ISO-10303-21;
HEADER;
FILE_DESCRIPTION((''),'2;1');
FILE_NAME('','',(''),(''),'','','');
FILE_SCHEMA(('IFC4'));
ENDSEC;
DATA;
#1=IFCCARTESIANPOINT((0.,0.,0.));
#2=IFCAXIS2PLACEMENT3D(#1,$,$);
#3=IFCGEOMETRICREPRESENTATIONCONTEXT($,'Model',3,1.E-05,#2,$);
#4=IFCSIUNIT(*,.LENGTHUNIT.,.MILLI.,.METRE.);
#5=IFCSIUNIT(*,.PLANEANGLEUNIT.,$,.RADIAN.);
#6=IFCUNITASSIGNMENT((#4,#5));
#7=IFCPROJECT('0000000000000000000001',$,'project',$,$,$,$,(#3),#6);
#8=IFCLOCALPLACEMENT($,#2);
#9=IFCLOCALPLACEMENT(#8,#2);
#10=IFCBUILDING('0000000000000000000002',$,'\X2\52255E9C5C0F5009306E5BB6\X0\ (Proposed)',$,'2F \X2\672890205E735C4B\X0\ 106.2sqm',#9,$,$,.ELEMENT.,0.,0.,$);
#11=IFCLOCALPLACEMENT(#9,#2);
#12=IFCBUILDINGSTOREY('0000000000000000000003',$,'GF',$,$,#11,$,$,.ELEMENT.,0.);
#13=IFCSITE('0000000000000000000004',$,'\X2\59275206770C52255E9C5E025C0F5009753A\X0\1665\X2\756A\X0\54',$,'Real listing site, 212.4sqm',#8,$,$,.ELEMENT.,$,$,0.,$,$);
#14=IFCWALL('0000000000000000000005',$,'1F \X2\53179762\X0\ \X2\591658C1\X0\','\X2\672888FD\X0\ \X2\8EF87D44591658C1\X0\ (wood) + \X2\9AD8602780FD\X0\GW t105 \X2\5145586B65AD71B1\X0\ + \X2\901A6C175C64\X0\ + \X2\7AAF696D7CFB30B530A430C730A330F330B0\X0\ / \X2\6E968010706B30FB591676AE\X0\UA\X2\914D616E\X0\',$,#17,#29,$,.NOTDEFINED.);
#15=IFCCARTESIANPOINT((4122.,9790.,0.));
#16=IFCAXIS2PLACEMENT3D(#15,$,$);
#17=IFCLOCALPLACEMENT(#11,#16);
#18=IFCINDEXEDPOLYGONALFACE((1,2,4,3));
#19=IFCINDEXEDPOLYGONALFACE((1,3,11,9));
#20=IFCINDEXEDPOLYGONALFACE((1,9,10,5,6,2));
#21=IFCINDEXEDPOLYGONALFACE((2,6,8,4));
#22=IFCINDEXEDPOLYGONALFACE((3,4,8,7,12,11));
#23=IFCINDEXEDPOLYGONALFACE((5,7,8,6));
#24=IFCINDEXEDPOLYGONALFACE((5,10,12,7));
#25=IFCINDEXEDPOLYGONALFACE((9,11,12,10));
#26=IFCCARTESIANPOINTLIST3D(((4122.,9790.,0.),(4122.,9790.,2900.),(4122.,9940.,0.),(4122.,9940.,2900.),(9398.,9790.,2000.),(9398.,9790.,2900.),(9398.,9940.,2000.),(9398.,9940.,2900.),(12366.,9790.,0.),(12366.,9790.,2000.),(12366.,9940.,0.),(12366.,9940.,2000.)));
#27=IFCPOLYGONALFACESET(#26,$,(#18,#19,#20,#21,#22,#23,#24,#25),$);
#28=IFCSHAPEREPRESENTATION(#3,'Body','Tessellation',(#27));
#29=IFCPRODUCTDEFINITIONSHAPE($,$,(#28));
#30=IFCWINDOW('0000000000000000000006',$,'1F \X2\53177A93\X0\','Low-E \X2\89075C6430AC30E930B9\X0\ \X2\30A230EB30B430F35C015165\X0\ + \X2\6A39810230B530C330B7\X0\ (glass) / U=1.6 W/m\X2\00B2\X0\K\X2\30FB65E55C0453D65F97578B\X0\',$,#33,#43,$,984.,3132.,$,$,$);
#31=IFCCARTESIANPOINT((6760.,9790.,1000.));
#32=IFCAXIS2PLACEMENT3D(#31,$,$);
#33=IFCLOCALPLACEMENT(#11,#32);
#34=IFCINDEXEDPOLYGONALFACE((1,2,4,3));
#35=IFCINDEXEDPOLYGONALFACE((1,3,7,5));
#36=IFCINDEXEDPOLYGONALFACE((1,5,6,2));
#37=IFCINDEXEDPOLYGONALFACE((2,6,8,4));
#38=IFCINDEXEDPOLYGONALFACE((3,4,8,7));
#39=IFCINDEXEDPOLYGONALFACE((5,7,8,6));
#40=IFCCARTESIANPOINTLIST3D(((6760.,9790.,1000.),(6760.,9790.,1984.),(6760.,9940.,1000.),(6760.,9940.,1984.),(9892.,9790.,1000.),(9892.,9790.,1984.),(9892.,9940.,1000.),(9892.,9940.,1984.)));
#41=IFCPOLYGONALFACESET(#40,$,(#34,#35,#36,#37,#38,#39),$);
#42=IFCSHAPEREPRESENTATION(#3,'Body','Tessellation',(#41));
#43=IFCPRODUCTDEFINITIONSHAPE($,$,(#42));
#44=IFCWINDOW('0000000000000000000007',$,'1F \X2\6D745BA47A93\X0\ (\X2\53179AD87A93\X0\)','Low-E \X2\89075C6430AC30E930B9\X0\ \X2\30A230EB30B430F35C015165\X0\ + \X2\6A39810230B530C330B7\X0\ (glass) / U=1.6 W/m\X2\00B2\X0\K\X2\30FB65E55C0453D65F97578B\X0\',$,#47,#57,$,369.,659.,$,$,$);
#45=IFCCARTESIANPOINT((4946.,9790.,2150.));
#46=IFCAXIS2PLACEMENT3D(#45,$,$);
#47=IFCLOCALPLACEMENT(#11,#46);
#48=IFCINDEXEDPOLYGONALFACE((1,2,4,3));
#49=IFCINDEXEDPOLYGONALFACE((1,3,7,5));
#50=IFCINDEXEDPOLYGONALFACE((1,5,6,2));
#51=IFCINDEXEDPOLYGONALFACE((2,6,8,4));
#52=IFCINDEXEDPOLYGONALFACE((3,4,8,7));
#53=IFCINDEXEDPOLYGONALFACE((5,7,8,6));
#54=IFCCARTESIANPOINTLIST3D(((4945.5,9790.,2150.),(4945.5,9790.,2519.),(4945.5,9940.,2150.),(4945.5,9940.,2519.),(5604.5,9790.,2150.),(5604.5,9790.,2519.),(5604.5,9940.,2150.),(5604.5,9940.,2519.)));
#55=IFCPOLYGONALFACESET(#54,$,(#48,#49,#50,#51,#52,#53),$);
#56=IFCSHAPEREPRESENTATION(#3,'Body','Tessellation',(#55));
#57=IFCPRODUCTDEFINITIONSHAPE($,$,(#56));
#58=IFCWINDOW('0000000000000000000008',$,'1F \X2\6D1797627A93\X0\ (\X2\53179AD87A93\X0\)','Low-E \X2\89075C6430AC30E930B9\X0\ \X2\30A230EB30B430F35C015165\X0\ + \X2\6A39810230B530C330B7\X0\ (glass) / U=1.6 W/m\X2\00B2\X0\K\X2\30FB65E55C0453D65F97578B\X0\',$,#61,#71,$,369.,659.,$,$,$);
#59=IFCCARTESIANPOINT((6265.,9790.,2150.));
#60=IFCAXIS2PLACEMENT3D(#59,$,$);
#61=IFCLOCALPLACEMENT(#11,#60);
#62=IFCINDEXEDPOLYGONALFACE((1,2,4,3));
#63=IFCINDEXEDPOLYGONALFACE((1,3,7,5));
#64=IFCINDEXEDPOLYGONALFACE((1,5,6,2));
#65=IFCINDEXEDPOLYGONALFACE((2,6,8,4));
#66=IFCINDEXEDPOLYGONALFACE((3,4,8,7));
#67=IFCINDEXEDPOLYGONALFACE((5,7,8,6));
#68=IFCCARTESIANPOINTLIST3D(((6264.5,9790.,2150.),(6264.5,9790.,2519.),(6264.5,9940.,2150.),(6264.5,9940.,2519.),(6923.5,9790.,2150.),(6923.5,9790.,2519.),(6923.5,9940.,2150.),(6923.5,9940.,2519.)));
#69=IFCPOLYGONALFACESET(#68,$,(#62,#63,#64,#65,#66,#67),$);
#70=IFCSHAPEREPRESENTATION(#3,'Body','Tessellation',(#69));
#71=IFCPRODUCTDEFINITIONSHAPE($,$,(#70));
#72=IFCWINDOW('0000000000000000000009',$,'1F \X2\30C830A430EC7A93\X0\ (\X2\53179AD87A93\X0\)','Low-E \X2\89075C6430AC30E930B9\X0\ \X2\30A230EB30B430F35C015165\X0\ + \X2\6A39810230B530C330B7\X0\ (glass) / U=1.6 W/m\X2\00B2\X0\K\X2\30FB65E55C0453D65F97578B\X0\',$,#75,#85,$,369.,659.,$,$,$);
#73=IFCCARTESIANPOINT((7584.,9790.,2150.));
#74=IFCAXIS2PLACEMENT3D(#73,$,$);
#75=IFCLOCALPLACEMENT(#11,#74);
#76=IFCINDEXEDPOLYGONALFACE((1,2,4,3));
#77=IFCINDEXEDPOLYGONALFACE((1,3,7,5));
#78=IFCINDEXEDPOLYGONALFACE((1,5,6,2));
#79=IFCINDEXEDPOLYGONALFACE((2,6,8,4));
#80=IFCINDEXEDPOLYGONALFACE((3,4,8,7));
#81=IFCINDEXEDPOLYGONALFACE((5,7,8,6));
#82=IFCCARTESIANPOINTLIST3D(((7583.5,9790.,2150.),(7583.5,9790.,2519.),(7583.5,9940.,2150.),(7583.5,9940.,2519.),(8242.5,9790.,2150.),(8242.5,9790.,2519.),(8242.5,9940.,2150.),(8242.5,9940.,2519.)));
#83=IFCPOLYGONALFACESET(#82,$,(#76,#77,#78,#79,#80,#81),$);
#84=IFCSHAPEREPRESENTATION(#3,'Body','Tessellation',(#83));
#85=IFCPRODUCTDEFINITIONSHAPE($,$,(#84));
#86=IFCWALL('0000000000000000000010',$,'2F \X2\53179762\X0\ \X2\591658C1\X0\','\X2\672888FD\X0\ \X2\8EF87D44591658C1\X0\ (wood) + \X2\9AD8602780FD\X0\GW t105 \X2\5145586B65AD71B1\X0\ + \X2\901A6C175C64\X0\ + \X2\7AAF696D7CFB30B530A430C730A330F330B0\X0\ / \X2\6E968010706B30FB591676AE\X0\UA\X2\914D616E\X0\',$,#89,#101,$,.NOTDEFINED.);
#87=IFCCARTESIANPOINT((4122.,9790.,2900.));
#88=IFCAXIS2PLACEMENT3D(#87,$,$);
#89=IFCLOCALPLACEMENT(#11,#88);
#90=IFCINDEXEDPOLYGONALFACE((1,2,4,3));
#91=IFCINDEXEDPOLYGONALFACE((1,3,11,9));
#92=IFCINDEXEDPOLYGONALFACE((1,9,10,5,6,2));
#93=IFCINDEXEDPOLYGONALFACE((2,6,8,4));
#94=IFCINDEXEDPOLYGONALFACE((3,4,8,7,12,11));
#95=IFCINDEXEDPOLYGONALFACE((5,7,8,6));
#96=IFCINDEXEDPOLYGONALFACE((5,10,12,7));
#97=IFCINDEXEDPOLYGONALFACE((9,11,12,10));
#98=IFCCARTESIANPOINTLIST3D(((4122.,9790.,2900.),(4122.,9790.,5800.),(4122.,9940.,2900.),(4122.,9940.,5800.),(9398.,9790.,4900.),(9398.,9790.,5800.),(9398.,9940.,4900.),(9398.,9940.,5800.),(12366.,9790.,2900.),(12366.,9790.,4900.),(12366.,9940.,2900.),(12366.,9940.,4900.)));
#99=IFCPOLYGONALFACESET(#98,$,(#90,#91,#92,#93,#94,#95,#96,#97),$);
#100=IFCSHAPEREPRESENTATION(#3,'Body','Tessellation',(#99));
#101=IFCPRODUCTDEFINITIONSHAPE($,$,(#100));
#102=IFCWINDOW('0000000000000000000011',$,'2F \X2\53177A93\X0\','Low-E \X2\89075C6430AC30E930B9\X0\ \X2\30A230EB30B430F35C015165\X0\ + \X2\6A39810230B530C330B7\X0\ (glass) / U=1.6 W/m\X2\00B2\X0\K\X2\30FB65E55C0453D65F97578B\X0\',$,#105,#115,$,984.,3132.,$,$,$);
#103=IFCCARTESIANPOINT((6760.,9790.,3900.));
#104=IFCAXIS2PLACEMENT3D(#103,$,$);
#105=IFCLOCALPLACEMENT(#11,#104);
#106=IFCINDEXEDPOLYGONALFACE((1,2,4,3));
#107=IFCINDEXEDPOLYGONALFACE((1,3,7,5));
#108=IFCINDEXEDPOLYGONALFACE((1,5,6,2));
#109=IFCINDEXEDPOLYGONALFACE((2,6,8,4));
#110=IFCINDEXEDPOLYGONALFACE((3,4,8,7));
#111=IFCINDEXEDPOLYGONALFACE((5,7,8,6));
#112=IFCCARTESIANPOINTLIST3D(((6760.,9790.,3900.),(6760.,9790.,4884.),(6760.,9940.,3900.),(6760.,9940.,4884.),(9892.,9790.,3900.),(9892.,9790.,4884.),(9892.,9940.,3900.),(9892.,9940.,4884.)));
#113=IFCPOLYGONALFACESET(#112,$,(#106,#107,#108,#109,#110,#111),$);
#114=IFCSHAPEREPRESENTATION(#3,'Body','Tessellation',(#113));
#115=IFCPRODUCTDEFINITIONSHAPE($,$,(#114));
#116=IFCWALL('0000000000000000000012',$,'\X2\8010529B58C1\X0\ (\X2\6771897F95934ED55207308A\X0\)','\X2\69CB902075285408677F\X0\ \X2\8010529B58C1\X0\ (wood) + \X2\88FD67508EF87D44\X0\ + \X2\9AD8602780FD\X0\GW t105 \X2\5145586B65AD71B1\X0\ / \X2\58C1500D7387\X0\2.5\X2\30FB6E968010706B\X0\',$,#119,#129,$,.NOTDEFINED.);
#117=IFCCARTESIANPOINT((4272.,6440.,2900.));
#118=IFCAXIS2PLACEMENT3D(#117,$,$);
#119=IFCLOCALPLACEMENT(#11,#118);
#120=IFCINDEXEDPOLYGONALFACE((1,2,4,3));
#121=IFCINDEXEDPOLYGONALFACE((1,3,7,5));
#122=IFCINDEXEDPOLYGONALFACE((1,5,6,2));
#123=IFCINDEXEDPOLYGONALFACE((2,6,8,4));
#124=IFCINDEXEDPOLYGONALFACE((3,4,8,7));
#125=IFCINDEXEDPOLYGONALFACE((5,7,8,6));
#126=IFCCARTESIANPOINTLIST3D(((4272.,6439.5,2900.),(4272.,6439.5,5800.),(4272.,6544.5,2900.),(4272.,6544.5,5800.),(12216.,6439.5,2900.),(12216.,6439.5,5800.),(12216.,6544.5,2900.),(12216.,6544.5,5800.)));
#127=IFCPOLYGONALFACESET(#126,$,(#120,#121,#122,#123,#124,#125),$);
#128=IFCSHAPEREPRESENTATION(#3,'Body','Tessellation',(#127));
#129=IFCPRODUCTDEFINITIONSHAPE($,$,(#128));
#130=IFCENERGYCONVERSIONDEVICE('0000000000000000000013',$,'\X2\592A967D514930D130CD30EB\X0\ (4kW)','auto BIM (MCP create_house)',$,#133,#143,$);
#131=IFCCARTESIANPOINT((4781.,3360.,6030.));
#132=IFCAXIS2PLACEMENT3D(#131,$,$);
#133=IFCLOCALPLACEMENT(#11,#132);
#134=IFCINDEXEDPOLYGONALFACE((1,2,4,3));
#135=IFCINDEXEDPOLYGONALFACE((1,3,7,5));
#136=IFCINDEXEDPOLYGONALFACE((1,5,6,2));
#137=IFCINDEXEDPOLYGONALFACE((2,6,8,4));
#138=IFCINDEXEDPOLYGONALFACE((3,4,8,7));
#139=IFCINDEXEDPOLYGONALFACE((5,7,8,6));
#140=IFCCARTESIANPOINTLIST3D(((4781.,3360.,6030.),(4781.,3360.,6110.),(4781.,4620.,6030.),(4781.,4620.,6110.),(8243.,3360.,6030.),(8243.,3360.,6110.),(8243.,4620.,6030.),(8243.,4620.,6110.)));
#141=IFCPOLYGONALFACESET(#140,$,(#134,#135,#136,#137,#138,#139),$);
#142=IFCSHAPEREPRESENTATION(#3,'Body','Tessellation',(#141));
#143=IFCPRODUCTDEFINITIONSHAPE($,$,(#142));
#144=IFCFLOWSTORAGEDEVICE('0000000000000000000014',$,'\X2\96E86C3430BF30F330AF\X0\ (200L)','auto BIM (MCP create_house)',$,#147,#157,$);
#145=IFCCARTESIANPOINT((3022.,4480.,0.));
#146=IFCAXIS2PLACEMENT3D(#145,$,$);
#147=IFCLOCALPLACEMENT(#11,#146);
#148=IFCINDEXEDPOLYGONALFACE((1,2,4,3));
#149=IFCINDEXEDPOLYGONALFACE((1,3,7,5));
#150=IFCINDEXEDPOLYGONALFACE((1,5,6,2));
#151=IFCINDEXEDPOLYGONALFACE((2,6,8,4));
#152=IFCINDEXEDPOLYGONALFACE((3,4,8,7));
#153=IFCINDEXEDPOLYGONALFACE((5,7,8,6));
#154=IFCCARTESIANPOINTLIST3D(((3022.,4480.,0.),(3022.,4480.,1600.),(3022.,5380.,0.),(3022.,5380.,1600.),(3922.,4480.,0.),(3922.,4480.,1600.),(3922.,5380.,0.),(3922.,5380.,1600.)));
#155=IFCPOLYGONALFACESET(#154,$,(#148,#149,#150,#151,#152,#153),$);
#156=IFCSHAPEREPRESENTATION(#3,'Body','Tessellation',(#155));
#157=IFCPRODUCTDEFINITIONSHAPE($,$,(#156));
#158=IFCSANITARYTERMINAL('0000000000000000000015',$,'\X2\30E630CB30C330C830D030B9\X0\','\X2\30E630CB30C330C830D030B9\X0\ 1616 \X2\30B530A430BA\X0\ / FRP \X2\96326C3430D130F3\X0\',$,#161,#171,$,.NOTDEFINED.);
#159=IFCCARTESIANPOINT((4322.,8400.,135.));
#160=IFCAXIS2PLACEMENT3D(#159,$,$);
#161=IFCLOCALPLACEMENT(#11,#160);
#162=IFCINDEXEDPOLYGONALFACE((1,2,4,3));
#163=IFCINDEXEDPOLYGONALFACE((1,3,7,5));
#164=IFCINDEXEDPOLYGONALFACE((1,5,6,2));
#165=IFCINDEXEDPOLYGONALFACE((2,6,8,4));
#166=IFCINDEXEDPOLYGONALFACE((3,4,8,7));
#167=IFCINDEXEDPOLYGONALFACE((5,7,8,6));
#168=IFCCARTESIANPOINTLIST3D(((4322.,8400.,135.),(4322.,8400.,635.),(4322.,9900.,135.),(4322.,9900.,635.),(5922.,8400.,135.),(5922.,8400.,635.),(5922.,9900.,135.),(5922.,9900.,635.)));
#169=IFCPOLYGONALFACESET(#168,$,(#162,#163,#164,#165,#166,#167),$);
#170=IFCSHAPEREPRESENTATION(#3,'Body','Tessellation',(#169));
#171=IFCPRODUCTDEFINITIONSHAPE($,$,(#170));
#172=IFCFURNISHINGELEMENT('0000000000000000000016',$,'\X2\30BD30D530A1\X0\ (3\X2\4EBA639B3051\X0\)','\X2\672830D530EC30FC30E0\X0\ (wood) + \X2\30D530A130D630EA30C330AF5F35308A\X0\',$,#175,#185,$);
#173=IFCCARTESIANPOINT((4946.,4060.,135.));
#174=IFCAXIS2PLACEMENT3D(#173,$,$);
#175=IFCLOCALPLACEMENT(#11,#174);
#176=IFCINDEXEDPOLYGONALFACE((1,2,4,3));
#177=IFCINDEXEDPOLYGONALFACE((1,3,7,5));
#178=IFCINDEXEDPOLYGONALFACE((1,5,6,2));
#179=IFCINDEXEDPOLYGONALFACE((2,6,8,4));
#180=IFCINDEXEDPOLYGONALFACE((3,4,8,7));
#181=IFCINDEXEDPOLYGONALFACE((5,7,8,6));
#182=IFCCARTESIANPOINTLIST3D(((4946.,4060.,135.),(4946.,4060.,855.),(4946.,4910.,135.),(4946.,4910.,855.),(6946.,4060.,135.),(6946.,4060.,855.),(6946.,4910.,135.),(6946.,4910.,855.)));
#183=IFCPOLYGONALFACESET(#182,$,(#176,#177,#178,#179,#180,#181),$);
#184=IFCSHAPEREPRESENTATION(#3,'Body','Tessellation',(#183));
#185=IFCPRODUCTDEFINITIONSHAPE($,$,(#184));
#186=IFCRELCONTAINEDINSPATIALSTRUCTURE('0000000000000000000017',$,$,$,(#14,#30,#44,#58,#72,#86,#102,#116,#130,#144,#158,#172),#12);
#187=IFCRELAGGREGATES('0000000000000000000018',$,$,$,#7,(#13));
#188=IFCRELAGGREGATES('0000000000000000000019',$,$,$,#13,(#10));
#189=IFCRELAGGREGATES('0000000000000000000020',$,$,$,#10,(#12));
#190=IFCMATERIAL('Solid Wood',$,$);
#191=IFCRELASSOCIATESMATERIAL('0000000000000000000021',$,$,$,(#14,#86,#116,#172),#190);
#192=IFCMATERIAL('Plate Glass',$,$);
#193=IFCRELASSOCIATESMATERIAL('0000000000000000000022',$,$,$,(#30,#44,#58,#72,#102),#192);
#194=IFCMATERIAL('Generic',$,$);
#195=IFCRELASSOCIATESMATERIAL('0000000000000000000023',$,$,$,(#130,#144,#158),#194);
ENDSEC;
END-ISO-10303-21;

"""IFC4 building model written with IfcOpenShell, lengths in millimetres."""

from ifc_helpers import new_model, si_unit, frame, frame_2d, origin, place, context, project, spatial, rectangle, extrude, material, element, fill, save


model = new_model("IFC4")

# Units and contexts
model_context = context("Model", 3, precision=1e-05, world=origin())
ifc_project = project(units=[si_unit("LENGTHUNIT", "METRE", prefix="MILLI"), si_unit("PLANEANGLEUNIT", "RADIAN")], contexts=[model_context])

# Site, building, storey
site_placement = place(None, origin())
site = spatial("IfcSite", under=ifc_project, at=site_placement, Name="大分県別府市小倉町1665番54", ObjectType="Real listing site, 212.4sqm", CompositionType="ELEMENT", RefElevation=0.0)
building_placement = place(site_placement, origin())
building = spatial("IfcBuilding", under=site, at=building_placement, Name="別府小倉の家 (Proposed)", ObjectType="2F 木造平屋 106.2sqm", CompositionType="ELEMENT", ElevationOfRefHeight=0.0, ElevationOfTerrain=0.0)
storey_placement = place(building_placement, origin())
storey = spatial("IfcBuildingStorey", under=building, at=storey_placement, Name="GF", CompositionType="ELEMENT", Elevation=0.0)

# Wall, openings, windows
ifc_material_1 = material(Name="Solid Wood")
wall_1_placement = place(storey_placement, frame((4122.0, 9790.0, 0.0)))
wall_1 = element("IfcWall", 1, at=wall_1_placement, inside=storey, material=ifc_material_1, Name="1F 北面 外壁", Description="木製 軸組外壁 (wood) + 高性能GW t105 充填断熱 + 通気層 + 窯業系サイディング / 準耐火・外皮UA配慮", PredefinedType="NOTDEFINED", context=model_context, shape_type="SweptSolid", body=[
    extrude(rectangle(XDim=8244.0, YDim=150.0, at=frame_2d((4122.0, 75.0))), frame((4122.0, 9790.0, 0.0)), (0.0, 0.0, 1.0), 2900.0),
])
opening_1_placement = place(storey_placement, frame((6760.0, 9790.0, 1000.0)))
opening_1 = element("IfcOpeningElement", 2, at=opening_1_placement, cuts=wall_1, PredefinedType="NOTDEFINED", context=model_context, shape_type="SweptSolid", body=[
    extrude(rectangle(XDim=3132.0, YDim=150.0, at=frame_2d((1566.0, 75.0))), frame((6760.0, 9790.0, 1000.0)), (0.0, 0.0, 1.0), 984.0),
])
opening_2_placement = place(storey_placement, frame((4946.0, 9790.0, 2150.0)))
opening_2 = element("IfcOpeningElement", 3, at=opening_2_placement, cuts=wall_1, PredefinedType="NOTDEFINED", context=model_context, shape_type="SweptSolid", body=[
    extrude(rectangle(XDim=659.0, YDim=150.0, at=frame_2d((329.0, 75.0))), frame((4946.0, 9790.0, 2150.0)), (0.0, 0.0, 1.0), 369.0),
])
opening_3_placement = place(storey_placement, frame((6265.0, 9790.0, 2150.0)))
opening_3 = element("IfcOpeningElement", 4, at=opening_3_placement, cuts=wall_1, PredefinedType="NOTDEFINED", context=model_context, shape_type="SweptSolid", body=[
    extrude(rectangle(XDim=659.0, YDim=150.0, at=frame_2d((329.0, 75.0))), frame((6265.0, 9790.0, 2150.0)), (0.0, 0.0, 1.0), 369.0),
])
opening_4_placement = place(storey_placement, frame((7584.0, 9790.0, 2150.0)))
opening_4 = element("IfcOpeningElement", 5, at=opening_4_placement, cuts=wall_1, PredefinedType="NOTDEFINED", context=model_context, shape_type="SweptSolid", body=[
    extrude(rectangle(XDim=659.0, YDim=150.0, at=frame_2d((329.0, 75.0))), frame((7584.0, 9790.0, 2150.0)), (0.0, 0.0, 1.0), 369.0),
])
ifc_material_2 = material(Name="Plate Glass")
window_1_placement = place(storey_placement, frame((6760.0, 9790.0, 1000.0)))
window_1 = element("IfcWindow", 6, at=window_1_placement, inside=storey, material=ifc_material_2, Name="1F 北窓", Description="Low-E 複層ガラス アルゴン封入 + 樹脂サッシ (glass) / U=1.6 W/m²K・日射取得型", OverallHeight=984.0, OverallWidth=3132.0, context=model_context, shape_type="SweptSolid", body=[
    extrude(rectangle(XDim=3132.0, YDim=150.0, at=frame_2d((1566.0, 75.0))), frame((6760.0, 9790.0, 1000.0)), (0.0, 0.0, 1.0), 984.0),
])
fill(opening_1, window_1)
window_2_placement = place(storey_placement, frame((4946.0, 9790.0, 2150.0)))
window_2 = element("IfcWindow", 7, at=window_2_placement, inside=storey, material=ifc_material_2, Name="1F 浴室窓 (北高窓)", Description="Low-E 複層ガラス アルゴン封入 + 樹脂サッシ (glass) / U=1.6 W/m²K・日射取得型", OverallHeight=369.0, OverallWidth=659.0, context=model_context, shape_type="SweptSolid", body=[
    extrude(rectangle(XDim=659.0, YDim=150.0, at=frame_2d((329.0, 75.0))), frame((4946.0, 9790.0, 2150.0)), (0.0, 0.0, 1.0), 369.0),
])
fill(opening_2, window_2)
window_3_placement = place(storey_placement, frame((6265.0, 9790.0, 2150.0)))
window_3 = element("IfcWindow", 8, at=window_3_placement, inside=storey, material=ifc_material_2, Name="1F 洗面窓 (北高窓)", Description="Low-E 複層ガラス アルゴン封入 + 樹脂サッシ (glass) / U=1.6 W/m²K・日射取得型", OverallHeight=369.0, OverallWidth=659.0, context=model_context, shape_type="SweptSolid", body=[
    extrude(rectangle(XDim=659.0, YDim=150.0, at=frame_2d((329.0, 75.0))), frame((6265.0, 9790.0, 2150.0)), (0.0, 0.0, 1.0), 369.0),
])
fill(opening_3, window_3)
window_4_placement = place(storey_placement, frame((7584.0, 9790.0, 2150.0)))
window_4 = element("IfcWindow", 9, at=window_4_placement, inside=storey, material=ifc_material_2, Name="1F トイレ窓 (北高窓)", Description="Low-E 複層ガラス アルゴン封入 + 樹脂サッシ (glass) / U=1.6 W/m²K・日射取得型", OverallHeight=369.0, OverallWidth=659.0, context=model_context, shape_type="SweptSolid", body=[
    extrude(rectangle(XDim=659.0, YDim=150.0, at=frame_2d((329.0, 75.0))), frame((7584.0, 9790.0, 2150.0)), (0.0, 0.0, 1.0), 369.0),
])
fill(opening_4, window_4)

# Wall, opening, window
wall_2_placement = place(storey_placement, frame((4122.0, 9790.0, 2900.0)))
wall_2 = element("IfcWall", 10, at=wall_2_placement, inside=storey, material=ifc_material_1, Name="2F 北面 外壁", Description="木製 軸組外壁 (wood) + 高性能GW t105 充填断熱 + 通気層 + 窯業系サイディング / 準耐火・外皮UA配慮", PredefinedType="NOTDEFINED", context=model_context, shape_type="SweptSolid", body=[
    extrude(rectangle(XDim=8244.0, YDim=150.0, at=frame_2d((4122.0, 75.0))), frame((4122.0, 9790.0, 2900.0)), (0.0, 0.0, 1.0), 2900.0),
])
opening_5_placement = place(storey_placement, frame((6760.0, 9790.0, 3900.0)))
opening_5 = element("IfcOpeningElement", 11, at=opening_5_placement, cuts=wall_2, PredefinedType="NOTDEFINED", context=model_context, shape_type="SweptSolid", body=[
    extrude(rectangle(XDim=3132.0, YDim=150.0, at=frame_2d((1566.0, 75.0))), frame((6760.0, 9790.0, 3900.0)), (0.0, 0.0, 1.0), 984.0),
])
window_5_placement = place(storey_placement, frame((6760.0, 9790.0, 3900.0)))
window_5 = element("IfcWindow", 12, at=window_5_placement, inside=storey, material=ifc_material_2, Name="2F 北窓", Description="Low-E 複層ガラス アルゴン封入 + 樹脂サッシ (glass) / U=1.6 W/m²K・日射取得型", OverallHeight=984.0, OverallWidth=3132.0, context=model_context, shape_type="SweptSolid", body=[
    extrude(rectangle(XDim=3132.0, YDim=150.0, at=frame_2d((1566.0, 75.0))), frame((6760.0, 9790.0, 3900.0)), (0.0, 0.0, 1.0), 984.0),
])
fill(opening_5, window_5)

# Wall
wall_3_placement = place(storey_placement, frame((4272.0, 6440.0, 2900.0)))
element("IfcWall", 13, at=wall_3_placement, inside=storey, material=ifc_material_1, Name="耐力壁 (東西間仕切り)", Description="構造用合板 耐力壁 (wood) + 製材軸組 + 高性能GW t105 充填断熱 / 壁倍率2.5・準耐火", PredefinedType="NOTDEFINED", context=model_context, shape_type="SweptSolid", body=[
    extrude(rectangle(XDim=7944.0, YDim=105.0, at=frame_2d((3972.0, 52.0))), frame((4272.0, 6440.0, 2900.0)), (0.0, 0.0, 1.0), 2900.0),
])

# Energy conversion device
ifc_material_3 = material(Name="Generic")
energy_conversion_device_placement = place(storey_placement, frame((4781.0, 3360.0, 6030.0)))
element("IfcEnergyConversionDevice", 14, at=energy_conversion_device_placement, inside=storey, material=ifc_material_3, Name="太陽光パネル (4kW)", Description="auto BIM (MCP create_house)", context=model_context, shape_type="SweptSolid", body=[
    extrude(rectangle(XDim=3462.0, YDim=1260.0, at=frame_2d((1731.0, 630.0))), frame((4781.0, 3360.0, 6030.0)), (0.0, 0.0, 1.0), 80.0),
])

# Flow storage device
flow_storage_device_placement = place(storey_placement, frame((3022.0, 4480.0, 0.0)))
element("IfcFlowStorageDevice", 15, at=flow_storage_device_placement, inside=storey, material=ifc_material_3, Name="雨水タンク (200L)", Description="auto BIM (MCP create_house)", context=model_context, shape_type="SweptSolid", body=[
    extrude(rectangle(XDim=900.0, YDim=900.0, at=frame_2d((450.0, 450.0))), frame((3022.0, 4480.0, 0.0)), (0.0, 0.0, 1.0), 1600.0),
])

# Sanitary terminal
sanitary_terminal_placement = place(storey_placement, frame((4322.0, 8400.0, 135.0)))
element("IfcSanitaryTerminal", 16, at=sanitary_terminal_placement, inside=storey, material=ifc_material_3, Name="ユニットバス", Description="ユニットバス 1616 サイズ / FRP 防水パン", PredefinedType="NOTDEFINED", context=model_context, shape_type="SweptSolid", body=[
    extrude(rectangle(XDim=1600.0, YDim=1500.0, at=frame_2d((800.0, 750.0))), frame((4322.0, 8400.0, 135.0)), (0.0, 0.0, 1.0), 500.0),
])

# Furnishing element
furnishing_1_placement = place(storey_placement, frame((4946.0, 4060.0, 135.0)))
element("IfcFurnishingElement", 17, at=furnishing_1_placement, inside=storey, material=ifc_material_1, Name="ソファ (3人掛け)", Description="木フレーム (wood) + ファブリック張り", context=model_context, shape_type="SweptSolid", body=[
    extrude(rectangle(XDim=2000.0, YDim=850.0, at=frame_2d((1000.0, 425.0))), frame((4946.0, 4060.0, 135.0)), (0.0, 0.0, 1.0), 720.0),
])

save(model, "model.ifc")
